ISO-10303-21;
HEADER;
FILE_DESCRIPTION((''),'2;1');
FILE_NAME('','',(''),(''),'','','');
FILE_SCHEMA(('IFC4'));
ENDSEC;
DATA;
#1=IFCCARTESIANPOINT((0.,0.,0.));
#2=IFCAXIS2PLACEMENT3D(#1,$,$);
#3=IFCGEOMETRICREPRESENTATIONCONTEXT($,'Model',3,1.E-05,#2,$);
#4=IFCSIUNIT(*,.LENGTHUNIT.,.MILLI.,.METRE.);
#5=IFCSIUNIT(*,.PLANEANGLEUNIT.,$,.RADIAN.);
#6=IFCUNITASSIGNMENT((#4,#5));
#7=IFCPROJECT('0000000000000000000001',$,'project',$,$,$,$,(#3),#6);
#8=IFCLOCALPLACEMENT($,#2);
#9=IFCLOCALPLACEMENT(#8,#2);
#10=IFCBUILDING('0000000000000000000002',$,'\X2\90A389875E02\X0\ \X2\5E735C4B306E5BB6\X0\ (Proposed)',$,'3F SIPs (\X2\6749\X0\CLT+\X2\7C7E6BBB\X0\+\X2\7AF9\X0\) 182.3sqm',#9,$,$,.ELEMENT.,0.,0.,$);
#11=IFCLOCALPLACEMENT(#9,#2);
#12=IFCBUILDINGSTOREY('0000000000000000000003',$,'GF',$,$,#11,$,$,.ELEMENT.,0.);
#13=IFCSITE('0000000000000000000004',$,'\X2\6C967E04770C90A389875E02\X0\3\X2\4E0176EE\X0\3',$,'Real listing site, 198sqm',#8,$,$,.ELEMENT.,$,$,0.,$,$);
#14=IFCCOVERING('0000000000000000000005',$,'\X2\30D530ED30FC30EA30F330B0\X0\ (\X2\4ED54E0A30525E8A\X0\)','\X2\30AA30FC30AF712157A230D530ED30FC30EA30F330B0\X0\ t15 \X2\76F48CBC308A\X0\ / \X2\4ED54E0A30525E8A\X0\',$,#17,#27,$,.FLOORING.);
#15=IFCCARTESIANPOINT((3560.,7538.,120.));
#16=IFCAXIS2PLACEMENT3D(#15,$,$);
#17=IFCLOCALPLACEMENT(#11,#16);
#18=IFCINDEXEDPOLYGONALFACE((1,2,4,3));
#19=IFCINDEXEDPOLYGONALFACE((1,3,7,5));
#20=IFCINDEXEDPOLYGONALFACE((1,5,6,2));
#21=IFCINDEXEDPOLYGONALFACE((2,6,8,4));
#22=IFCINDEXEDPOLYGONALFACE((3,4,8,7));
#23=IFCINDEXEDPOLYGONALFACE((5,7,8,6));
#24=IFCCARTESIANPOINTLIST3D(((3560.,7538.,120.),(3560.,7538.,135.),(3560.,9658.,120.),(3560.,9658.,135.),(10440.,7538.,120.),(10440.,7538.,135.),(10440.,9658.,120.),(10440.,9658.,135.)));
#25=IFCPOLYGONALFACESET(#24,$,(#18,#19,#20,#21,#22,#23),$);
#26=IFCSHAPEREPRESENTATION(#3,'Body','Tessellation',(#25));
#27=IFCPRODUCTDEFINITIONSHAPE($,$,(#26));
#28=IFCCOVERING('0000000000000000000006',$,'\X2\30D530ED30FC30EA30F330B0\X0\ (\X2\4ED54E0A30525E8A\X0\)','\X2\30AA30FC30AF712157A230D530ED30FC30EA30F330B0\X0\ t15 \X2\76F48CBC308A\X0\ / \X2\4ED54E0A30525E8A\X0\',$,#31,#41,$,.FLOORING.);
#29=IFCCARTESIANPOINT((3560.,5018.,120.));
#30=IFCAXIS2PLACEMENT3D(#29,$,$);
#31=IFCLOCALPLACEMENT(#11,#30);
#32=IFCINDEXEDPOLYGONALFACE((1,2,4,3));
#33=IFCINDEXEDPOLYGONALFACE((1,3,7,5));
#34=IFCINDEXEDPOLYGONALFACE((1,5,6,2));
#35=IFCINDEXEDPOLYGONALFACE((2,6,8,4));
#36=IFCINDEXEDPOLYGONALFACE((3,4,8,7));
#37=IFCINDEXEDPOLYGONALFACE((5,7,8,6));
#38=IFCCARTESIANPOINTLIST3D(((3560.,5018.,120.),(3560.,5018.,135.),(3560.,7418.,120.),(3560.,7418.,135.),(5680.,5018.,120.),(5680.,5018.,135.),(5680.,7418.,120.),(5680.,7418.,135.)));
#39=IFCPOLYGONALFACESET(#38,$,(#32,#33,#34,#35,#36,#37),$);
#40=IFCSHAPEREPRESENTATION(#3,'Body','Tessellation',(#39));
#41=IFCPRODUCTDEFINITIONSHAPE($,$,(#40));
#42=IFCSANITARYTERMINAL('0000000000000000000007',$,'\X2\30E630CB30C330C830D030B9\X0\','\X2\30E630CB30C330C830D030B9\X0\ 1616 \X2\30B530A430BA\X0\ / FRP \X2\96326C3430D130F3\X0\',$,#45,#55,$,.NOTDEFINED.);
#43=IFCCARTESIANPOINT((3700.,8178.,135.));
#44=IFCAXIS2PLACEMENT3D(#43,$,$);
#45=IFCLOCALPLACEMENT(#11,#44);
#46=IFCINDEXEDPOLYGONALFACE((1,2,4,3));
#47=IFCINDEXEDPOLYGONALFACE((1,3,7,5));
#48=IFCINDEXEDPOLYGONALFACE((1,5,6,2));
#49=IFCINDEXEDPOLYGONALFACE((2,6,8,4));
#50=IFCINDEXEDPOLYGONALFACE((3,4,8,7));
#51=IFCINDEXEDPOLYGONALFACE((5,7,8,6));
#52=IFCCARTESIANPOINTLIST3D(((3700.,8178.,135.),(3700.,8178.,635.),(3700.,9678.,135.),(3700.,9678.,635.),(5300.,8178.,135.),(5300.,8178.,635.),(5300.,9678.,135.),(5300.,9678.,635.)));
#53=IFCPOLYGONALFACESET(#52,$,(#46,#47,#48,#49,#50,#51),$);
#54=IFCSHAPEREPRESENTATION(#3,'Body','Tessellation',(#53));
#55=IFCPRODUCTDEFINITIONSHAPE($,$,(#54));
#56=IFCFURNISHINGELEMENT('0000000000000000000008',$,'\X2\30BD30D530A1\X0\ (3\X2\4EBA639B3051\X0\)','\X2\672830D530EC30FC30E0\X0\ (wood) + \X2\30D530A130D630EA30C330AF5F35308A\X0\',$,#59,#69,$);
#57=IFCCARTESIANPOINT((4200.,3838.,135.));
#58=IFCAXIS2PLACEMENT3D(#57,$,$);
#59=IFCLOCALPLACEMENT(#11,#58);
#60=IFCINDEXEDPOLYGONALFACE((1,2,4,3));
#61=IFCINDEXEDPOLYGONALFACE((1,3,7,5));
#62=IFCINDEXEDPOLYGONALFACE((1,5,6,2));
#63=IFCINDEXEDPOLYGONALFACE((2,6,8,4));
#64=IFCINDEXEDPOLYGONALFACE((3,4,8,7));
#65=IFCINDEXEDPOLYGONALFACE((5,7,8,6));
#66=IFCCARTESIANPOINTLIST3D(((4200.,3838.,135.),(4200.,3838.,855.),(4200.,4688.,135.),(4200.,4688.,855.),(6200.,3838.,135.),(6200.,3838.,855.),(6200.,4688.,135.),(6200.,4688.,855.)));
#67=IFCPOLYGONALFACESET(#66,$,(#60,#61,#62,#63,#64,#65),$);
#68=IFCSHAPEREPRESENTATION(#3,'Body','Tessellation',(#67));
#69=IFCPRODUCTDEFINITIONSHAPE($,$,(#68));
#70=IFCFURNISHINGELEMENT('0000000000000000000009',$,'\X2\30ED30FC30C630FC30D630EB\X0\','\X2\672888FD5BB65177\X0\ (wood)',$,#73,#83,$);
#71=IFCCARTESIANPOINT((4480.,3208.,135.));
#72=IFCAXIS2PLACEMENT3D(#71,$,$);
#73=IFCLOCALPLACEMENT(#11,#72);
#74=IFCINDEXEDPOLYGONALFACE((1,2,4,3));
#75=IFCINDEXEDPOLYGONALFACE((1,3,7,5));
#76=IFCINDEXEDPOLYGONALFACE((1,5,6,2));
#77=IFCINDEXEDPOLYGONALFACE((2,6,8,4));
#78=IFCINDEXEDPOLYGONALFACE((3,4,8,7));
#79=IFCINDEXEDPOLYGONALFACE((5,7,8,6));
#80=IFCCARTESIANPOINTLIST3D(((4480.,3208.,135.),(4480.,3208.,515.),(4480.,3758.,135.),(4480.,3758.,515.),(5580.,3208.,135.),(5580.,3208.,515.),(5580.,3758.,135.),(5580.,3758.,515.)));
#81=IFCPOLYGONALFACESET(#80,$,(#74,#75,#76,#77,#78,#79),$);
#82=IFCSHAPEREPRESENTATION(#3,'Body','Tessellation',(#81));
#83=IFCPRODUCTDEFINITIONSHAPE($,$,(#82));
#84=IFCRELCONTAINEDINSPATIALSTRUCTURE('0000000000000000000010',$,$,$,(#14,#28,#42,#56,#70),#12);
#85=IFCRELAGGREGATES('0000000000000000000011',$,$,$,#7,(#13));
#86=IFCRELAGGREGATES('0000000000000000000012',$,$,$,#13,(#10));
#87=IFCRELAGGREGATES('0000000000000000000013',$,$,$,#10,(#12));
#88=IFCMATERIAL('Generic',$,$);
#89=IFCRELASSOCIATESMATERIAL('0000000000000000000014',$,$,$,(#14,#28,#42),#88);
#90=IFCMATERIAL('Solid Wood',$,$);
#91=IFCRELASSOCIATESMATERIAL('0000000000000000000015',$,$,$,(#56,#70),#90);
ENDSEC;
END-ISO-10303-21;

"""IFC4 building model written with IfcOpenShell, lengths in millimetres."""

from ifc_helpers import new_model, si_unit, frame, frame_2d, origin, place, context, project, spatial, rectangle, extrude, material, element, save


model = new_model("IFC4")

# Units and contexts
model_context = context("Model", 3, precision=1e-05, world=origin())
ifc_project = project(units=[si_unit("LENGTHUNIT", "METRE", prefix="MILLI"), si_unit("PLANEANGLEUNIT", "RADIAN")], contexts=[model_context])

# Site, building, storey
site_placement = place(None, origin())
site = spatial("IfcSite", under=ifc_project, at=site_placement, Name="沖縄県那覇市3丁目3", ObjectType="Real listing site, 198sqm", CompositionType="ELEMENT", RefElevation=0.0)
building_placement = place(site_placement, origin())
building = spatial("IfcBuilding", under=site, at=building_placement, Name="那覇市 平屋の家 (Proposed)", ObjectType="3F SIPs (杉CLT+籾殻+竹) 182.3sqm", CompositionType="ELEMENT", ElevationOfRefHeight=0.0, ElevationOfTerrain=0.0)
storey_placement = place(building_placement, origin())
storey = spatial("IfcBuildingStorey", under=building, at=storey_placement, Name="GF", CompositionType="ELEMENT", Elevation=0.0)

# Shared definitions
ifc_material_1 = material(Name="Solid Wood")

# Coverings
ifc_material_2 = material(Name="Generic")
covering_1_placement = place(storey_placement, frame((3560.0, 7538.0, 120.0)))
element("IfcCovering", 1, at=covering_1_placement, inside=storey, material=ifc_material_2, Name="フローリング (仕上げ床)", Description="オーク無垢フローリング t15 直貼り / 仕上げ床", PredefinedType="FLOORING", context=model_context, shape_type="SweptSolid", body=[
    extrude(rectangle(XDim=6880.0, YDim=2120.0, at=frame_2d((3440.0, 1060.0))), frame((3560.0, 7538.0, 120.0)), (0.0, 0.0, 1.0), 15.0),
])
covering_2_placement = place(storey_placement, frame((3560.0, 5018.0, 120.0)))
element("IfcCovering", 2, at=covering_2_placement, inside=storey, material=ifc_material_2, Name="フローリング (仕上げ床)", Description="オーク無垢フローリング t15 直貼り / 仕上げ床", PredefinedType="FLOORING", context=model_context, shape_type="SweptSolid", body=[
    extrude(rectangle(XDim=2120.0, YDim=2400.0, at=frame_2d((1060.0, 1200.0))), frame((3560.0, 5018.0, 120.0)), (0.0, 0.0, 1.0), 15.0),
])

# Sanitary terminal
sanitary_terminal_placement = place(storey_placement, frame((3700.0, 8178.0, 135.0)))
element("IfcSanitaryTerminal", 3, at=sanitary_terminal_placement, inside=storey, material=ifc_material_2, Name="ユニットバス", Description="ユニットバス 1616 サイズ / FRP 防水パン", PredefinedType="NOTDEFINED", context=model_context, shape_type="SweptSolid", body=[
    extrude(rectangle(XDim=1600.0, YDim=1500.0, at=frame_2d((800.0, 750.0))), frame((3700.0, 8178.0, 135.0)), (0.0, 0.0, 1.0), 500.0),
])

# Furnishing elements
furnishing_1_placement = place(storey_placement, frame((4200.0, 3838.0, 135.0)))
element("IfcFurnishingElement", 4, at=furnishing_1_placement, inside=storey, material=ifc_material_1, Name="ソファ (3人掛け)", Description="木フレーム (wood) + ファブリック張り", context=model_context, shape_type="SweptSolid", body=[
    extrude(rectangle(XDim=2000.0, YDim=850.0, at=frame_2d((1000.0, 425.0))), frame((4200.0, 3838.0, 135.0)), (0.0, 0.0, 1.0), 720.0),
])
furnishing_2_placement = place(storey_placement, frame((4480.0, 3208.0, 135.0)))
element("IfcFurnishingElement", 5, at=furnishing_2_placement, inside=storey, material=ifc_material_1, Name="ローテーブル", Description="木製家具 (wood)", context=model_context, shape_type="SweptSolid", body=[
    extrude(rectangle(XDim=1100.0, YDim=550.0, at=frame_2d((550.0, 275.0))), frame((4480.0, 3208.0, 135.0)), (0.0, 0.0, 1.0), 380.0),
])

save(model, "model.ifc")
